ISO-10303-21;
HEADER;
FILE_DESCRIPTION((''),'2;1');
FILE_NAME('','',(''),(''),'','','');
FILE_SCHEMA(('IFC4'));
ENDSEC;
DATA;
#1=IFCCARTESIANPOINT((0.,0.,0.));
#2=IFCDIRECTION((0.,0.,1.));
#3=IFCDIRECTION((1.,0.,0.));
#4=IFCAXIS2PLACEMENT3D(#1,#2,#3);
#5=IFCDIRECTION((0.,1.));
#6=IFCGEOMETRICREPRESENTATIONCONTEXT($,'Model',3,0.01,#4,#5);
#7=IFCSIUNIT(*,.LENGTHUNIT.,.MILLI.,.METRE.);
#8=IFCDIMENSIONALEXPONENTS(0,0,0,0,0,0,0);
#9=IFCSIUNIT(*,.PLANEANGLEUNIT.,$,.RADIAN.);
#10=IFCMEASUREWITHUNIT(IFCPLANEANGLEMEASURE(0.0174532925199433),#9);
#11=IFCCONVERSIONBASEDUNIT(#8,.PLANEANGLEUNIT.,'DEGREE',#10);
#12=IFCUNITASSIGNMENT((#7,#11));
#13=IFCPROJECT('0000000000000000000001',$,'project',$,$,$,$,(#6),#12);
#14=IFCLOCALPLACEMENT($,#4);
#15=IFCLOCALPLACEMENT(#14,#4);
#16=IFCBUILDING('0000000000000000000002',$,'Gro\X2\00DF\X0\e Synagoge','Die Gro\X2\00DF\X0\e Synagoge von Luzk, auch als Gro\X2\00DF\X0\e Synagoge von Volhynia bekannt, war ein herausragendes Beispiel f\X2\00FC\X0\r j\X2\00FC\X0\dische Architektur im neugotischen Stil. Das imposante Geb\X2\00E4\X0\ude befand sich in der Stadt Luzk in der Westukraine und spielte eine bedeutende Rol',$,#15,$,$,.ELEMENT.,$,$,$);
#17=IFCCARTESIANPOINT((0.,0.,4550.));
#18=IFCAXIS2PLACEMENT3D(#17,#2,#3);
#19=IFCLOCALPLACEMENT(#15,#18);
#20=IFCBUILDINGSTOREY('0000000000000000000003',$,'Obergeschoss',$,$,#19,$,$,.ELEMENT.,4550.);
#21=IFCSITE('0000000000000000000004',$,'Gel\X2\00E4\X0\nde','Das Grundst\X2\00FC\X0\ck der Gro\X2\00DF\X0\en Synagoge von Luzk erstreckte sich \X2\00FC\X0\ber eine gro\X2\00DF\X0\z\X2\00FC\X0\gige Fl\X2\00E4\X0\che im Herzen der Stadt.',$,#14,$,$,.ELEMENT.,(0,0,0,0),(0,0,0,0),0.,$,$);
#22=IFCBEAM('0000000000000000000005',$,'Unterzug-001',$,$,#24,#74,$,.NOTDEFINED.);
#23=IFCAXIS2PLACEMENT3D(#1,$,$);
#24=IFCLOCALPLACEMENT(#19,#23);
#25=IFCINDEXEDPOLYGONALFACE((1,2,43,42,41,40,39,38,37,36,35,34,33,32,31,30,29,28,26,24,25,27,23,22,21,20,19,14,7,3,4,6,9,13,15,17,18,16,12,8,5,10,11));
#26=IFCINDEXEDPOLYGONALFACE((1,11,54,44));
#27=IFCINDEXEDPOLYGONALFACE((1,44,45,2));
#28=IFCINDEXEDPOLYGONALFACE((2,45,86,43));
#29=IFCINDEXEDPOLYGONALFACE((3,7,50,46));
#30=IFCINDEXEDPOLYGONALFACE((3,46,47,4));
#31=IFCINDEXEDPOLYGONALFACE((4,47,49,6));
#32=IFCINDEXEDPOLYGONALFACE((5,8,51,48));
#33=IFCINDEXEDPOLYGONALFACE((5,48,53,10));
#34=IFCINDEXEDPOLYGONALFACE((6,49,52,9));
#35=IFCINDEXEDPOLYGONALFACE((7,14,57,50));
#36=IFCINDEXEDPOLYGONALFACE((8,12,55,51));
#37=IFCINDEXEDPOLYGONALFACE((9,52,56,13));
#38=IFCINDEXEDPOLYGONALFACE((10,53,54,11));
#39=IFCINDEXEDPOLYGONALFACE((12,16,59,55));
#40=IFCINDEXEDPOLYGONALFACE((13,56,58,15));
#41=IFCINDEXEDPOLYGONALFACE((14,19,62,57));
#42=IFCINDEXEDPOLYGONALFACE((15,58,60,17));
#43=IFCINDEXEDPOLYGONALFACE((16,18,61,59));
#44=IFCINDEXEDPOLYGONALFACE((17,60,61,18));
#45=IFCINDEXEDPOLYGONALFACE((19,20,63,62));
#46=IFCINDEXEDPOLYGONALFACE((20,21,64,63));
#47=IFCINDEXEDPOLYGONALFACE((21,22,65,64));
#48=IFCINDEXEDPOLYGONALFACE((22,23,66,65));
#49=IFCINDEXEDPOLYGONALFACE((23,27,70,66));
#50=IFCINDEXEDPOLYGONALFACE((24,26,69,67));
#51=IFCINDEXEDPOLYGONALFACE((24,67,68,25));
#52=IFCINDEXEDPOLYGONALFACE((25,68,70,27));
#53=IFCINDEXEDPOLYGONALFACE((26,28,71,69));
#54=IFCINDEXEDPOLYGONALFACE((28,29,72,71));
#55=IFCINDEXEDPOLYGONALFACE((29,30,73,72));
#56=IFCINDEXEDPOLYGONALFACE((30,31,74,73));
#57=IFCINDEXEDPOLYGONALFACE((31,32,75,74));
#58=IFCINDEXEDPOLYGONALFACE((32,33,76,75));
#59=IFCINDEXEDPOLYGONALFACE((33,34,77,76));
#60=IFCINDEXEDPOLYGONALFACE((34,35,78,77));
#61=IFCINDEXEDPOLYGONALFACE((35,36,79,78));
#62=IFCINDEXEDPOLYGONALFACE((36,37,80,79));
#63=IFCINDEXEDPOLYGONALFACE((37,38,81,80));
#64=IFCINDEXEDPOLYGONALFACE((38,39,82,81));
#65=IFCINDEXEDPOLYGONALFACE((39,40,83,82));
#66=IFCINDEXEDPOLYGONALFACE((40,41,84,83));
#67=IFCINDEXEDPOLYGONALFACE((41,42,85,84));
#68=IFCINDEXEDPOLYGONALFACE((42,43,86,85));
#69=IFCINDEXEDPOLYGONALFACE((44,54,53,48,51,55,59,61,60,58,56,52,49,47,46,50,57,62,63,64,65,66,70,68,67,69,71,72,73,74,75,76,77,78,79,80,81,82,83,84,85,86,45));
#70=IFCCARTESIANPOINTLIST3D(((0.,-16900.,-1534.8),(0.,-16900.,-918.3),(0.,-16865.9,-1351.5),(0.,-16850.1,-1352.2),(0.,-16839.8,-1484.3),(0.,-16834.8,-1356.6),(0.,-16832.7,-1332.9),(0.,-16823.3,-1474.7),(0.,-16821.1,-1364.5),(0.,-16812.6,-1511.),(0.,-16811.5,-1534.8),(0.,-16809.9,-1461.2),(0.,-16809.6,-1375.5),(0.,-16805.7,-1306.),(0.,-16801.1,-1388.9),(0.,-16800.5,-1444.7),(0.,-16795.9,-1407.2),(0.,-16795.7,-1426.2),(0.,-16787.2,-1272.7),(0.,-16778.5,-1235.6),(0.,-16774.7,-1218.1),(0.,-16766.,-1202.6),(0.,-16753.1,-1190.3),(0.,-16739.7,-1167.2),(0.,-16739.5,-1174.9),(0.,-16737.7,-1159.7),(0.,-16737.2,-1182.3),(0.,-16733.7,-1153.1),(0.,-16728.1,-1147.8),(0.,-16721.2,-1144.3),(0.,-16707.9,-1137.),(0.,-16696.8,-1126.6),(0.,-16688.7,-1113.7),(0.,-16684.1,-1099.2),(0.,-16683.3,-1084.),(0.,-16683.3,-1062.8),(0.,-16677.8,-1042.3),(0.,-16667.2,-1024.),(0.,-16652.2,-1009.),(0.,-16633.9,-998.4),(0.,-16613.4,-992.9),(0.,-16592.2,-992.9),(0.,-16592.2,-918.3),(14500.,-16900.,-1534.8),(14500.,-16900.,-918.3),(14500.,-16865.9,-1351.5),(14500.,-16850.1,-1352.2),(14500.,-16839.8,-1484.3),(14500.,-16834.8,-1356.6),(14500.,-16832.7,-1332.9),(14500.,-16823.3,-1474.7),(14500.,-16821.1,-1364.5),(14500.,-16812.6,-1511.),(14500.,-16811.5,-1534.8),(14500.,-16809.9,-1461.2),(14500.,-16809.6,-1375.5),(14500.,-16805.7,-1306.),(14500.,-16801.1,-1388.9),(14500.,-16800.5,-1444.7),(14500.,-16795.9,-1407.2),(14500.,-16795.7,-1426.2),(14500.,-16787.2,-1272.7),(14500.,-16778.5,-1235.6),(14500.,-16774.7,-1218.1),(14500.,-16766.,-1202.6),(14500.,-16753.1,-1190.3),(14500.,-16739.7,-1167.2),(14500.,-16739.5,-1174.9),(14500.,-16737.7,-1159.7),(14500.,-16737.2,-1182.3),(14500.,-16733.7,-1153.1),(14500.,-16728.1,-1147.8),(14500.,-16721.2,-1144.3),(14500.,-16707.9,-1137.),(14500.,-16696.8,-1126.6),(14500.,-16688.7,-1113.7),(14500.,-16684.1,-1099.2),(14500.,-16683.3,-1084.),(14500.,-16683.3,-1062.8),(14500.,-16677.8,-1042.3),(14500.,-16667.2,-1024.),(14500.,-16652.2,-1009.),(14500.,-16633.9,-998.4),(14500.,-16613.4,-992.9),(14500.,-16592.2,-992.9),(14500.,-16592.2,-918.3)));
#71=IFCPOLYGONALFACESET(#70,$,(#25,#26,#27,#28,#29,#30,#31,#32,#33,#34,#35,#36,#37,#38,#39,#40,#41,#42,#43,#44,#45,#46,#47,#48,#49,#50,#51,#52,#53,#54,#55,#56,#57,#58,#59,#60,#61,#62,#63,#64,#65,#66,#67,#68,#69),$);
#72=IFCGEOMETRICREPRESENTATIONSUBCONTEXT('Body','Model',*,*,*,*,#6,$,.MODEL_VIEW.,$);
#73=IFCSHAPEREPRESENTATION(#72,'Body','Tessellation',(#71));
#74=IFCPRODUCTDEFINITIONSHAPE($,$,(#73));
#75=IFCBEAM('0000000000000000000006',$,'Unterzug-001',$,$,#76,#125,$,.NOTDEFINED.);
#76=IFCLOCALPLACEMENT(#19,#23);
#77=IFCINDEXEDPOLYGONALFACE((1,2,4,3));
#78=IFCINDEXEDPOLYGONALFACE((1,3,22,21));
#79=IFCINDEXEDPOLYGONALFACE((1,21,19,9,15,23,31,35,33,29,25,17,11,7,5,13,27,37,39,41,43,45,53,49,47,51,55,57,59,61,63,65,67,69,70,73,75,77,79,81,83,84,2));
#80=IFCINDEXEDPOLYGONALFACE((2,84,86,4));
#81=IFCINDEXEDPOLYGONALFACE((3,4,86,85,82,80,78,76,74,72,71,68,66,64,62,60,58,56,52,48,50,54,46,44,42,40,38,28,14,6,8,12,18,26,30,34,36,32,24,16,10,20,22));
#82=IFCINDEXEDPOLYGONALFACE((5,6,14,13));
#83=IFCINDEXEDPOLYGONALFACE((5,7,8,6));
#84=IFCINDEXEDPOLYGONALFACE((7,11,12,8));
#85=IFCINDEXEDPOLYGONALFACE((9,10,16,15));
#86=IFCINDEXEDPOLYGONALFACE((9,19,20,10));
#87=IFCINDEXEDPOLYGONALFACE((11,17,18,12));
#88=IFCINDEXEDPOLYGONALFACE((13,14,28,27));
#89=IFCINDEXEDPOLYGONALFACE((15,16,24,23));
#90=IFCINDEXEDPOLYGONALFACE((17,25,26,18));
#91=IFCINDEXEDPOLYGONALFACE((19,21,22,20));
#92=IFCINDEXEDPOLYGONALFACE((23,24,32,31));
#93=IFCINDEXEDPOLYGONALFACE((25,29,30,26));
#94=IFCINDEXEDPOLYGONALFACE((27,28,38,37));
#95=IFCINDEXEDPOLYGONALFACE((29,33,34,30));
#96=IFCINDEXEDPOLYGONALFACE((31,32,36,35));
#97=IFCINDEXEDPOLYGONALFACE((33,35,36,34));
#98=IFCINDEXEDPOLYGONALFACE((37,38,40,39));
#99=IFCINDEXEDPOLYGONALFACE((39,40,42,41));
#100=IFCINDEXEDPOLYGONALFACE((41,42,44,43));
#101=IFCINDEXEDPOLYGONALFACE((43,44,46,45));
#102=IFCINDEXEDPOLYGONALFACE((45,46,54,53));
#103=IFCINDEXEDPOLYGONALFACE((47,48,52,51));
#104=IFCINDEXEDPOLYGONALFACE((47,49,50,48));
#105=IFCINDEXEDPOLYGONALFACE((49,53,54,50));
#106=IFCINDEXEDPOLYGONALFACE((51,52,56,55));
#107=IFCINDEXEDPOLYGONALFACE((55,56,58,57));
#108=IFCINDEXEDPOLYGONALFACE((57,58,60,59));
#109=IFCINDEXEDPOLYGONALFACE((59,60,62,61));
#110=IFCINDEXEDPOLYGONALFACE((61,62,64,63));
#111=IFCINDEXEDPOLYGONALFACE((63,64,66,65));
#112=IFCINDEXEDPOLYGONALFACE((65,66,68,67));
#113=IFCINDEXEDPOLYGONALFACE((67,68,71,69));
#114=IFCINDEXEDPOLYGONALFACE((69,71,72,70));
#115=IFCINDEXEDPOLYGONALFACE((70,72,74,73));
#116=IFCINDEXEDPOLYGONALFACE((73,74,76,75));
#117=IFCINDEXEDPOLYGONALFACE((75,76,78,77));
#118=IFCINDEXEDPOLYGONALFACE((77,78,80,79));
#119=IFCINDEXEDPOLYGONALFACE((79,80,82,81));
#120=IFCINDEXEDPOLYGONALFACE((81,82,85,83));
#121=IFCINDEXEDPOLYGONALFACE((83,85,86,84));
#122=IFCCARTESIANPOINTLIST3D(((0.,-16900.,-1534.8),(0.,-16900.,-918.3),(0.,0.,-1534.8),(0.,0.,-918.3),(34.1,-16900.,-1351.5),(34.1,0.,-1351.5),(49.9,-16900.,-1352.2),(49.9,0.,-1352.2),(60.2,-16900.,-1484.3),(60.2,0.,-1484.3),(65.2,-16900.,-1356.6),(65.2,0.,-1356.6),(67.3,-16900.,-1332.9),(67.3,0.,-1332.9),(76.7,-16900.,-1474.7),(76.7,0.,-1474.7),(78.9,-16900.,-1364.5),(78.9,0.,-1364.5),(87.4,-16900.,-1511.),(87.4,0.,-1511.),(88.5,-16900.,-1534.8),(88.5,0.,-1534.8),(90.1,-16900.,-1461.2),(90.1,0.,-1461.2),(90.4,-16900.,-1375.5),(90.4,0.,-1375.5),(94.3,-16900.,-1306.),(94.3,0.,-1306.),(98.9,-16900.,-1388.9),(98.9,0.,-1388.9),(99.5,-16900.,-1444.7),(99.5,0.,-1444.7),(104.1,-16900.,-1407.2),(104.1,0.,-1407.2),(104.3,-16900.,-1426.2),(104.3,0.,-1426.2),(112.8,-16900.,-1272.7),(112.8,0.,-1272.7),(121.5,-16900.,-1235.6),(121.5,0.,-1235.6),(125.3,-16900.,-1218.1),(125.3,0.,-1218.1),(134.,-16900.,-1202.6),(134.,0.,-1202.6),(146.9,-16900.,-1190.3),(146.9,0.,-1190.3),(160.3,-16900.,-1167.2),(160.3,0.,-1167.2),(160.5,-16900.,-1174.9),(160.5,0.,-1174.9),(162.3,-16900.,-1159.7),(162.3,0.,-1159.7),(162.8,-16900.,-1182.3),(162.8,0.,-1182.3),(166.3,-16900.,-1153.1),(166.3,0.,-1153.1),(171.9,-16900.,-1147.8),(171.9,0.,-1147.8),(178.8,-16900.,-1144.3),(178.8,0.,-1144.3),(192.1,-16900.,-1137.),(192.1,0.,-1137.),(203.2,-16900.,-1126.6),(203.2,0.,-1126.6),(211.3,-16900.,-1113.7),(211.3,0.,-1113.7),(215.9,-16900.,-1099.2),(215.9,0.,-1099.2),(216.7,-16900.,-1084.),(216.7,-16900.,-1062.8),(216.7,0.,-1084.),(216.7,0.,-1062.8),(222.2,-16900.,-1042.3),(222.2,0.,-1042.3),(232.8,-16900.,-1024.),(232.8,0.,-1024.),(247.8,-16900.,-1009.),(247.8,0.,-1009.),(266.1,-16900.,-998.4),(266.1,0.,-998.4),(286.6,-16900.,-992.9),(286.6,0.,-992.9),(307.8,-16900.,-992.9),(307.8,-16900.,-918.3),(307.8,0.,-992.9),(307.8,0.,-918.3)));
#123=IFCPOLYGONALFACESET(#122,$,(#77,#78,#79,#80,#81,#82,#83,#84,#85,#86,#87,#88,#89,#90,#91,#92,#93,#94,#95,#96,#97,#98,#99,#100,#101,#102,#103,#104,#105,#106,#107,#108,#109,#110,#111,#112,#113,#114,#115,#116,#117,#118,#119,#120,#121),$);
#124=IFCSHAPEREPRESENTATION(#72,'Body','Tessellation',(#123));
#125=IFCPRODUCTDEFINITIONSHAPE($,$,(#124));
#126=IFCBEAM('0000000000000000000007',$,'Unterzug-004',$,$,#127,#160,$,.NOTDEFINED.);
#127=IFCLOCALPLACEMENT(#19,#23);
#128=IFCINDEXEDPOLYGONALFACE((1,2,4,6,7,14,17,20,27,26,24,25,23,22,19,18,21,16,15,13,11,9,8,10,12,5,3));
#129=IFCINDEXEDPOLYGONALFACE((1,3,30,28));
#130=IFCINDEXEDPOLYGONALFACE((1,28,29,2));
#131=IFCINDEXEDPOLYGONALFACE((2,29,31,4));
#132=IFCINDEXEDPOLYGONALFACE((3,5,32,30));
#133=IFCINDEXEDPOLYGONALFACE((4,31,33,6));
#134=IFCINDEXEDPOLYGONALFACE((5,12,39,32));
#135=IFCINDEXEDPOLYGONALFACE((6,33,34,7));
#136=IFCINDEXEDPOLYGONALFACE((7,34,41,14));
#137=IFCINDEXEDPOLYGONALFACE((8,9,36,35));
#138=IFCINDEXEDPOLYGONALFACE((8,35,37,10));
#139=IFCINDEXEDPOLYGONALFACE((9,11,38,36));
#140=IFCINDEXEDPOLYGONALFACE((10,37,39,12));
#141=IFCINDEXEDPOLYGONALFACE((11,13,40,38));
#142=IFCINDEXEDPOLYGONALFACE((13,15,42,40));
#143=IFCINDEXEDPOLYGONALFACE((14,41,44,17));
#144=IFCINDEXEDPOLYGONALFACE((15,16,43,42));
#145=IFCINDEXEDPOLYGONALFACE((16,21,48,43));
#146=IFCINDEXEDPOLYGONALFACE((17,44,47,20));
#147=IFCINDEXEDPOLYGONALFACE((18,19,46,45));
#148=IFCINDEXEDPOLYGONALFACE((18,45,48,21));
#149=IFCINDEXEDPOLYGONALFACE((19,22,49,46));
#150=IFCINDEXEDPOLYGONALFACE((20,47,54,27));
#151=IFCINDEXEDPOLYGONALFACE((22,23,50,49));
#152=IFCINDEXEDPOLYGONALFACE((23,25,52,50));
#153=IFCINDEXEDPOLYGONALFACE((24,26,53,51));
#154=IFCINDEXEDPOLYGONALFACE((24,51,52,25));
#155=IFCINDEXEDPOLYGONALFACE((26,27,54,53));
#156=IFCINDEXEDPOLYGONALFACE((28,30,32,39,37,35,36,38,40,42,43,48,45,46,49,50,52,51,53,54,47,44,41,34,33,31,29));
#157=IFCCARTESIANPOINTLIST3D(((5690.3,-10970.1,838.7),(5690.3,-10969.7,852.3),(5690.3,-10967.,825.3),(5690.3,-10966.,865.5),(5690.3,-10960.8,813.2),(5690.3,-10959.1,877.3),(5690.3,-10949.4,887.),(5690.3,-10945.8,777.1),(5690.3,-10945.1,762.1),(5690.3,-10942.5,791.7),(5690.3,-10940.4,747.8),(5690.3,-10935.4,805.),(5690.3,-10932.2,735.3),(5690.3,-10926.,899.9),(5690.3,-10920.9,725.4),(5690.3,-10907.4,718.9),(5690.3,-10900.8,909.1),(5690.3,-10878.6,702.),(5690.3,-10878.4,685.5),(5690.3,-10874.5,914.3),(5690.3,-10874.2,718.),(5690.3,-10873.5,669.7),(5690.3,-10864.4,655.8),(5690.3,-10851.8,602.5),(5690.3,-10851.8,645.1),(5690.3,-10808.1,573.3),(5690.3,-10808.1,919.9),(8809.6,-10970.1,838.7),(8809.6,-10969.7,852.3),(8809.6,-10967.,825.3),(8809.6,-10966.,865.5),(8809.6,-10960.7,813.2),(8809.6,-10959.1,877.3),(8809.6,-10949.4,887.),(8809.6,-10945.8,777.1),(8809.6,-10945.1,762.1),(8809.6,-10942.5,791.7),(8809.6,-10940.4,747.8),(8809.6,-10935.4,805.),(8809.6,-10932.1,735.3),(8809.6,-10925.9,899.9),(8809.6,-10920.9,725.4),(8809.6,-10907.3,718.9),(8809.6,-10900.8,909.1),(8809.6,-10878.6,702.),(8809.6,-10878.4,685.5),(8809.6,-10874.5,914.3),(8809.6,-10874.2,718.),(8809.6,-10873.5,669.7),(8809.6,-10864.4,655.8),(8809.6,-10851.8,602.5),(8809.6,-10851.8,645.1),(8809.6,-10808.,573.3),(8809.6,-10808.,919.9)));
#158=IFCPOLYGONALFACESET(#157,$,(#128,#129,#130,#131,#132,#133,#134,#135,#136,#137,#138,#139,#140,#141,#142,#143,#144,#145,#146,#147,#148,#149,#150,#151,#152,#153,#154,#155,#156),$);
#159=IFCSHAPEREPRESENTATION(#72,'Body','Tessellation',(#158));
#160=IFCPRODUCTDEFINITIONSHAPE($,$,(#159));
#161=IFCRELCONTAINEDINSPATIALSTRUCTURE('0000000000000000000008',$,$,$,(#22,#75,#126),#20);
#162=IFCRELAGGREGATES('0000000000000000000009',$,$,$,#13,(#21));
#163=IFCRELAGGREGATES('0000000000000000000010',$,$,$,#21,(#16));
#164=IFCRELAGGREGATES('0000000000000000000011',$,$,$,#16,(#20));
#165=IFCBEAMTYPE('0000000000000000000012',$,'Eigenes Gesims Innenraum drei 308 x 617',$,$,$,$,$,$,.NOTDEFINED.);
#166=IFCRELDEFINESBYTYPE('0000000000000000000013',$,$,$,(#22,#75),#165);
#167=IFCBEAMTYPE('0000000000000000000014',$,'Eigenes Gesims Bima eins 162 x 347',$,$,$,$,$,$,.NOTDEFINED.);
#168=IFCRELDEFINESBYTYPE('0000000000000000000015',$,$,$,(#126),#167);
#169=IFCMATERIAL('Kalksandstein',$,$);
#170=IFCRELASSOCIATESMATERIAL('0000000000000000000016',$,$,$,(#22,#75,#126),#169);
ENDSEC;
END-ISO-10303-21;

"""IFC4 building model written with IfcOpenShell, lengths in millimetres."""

from ifc_helpers import new_model, entity, si_unit, converted_unit, direction, frame, origin_with_axes, place, context, subcontext, project, spatial, line, arc, indexed_curve, outline, extrude, material, material_profile, profile_set, type_object, element, save


model = new_model("IFC4")

# Units and contexts
model_context = context("Model", 3, precision=0.01, world=origin_with_axes(), true_north=direction((0.0, 1.0)))
body_context = subcontext(model_context, "Body", "Model", "MODEL_VIEW")
ifc_project = project(units=[si_unit("LENGTHUNIT", "METRE", prefix="MILLI"), converted_unit("PLANEANGLEUNIT", "DEGREE", entity("IfcPlaneAngleMeasure", 0.0174532925199433), si_unit("PLANEANGLEUNIT", "RADIAN"), dimensions=[0, 0, 0, 0, 0, 0, 0])], contexts=[model_context])

# Site, building, storey
site_placement = place(None, origin_with_axes())
site = spatial("IfcSite", under=ifc_project, at=site_placement, Name="Gelände", Description="Das Grundstück der Großen Synagoge von Luzk erstreckte sich über eine großzügige Fläche im Herzen der Stadt.", CompositionType="ELEMENT", RefLatitude=(0, 0, 0, 0), RefLongitude=(0, 0, 0, 0), RefElevation=0.0)
building_placement = place(site_placement, origin_with_axes())
building = spatial("IfcBuilding", under=site, at=building_placement, Name="Große Synagoge", Description="Die Große Synagoge von Luzk, auch als Große Synagoge von Volhynia bekannt, war ein herausragendes Beispiel für jüdische Architektur im neugotischen Stil. Das imposante Gebäude befand sich in der Stadt Luzk in der Westukraine und spielte eine bedeutende Rol", CompositionType="ELEMENT")
storey_placement = place(building_placement, frame((0.0, 0.0, 4550.0), z_axis=(0.0, 0.0, 1.0), x_axis=(1.0, 0.0, 0.0)))
storey = spatial("IfcBuildingStorey", under=building, at=storey_placement, Name="Obergeschoss", CompositionType="ELEMENT", Elevation=4550.0)

# Beams
ifc_material_1 = material(Name="Kalksandstein")
ifc_material_profile_1 = material_profile(ifc_material_1, outline(indexed_curve([(121.5, -317.3), (134.0, -284.3), (162.8, -264.0), (162.3, -241.4), (178.8, -226.0), (207.7, -202.1), (216.7, -165.7), (239.8, -97.7), (307.8, -74.6), (307.8, 0.0), (0.0, 0.0), (0.0, -616.6), (88.5, -616.6), (87.4, -592.7), (60.2, -566.0), (99.5, -526.4), (98.9, -470.6), (72.3, -441.9), (34.1, -433.2), (94.3, -387.7)], segments=[arc(1, 2, 3), arc(3, 4, 5), arc(5, 6, 7), arc(7, 8, 9), line(9, 10, 11, 12, 13, 14, 15), arc(15, 16, 17), arc(17, 18, 19), arc(19, 20, 1)])), Name="Kalksandstein")
ifc_profile_set_1 = profile_set([ifc_material_profile_1], Name="Eigenes Gesims Innenraum drei")
beam_type_1 = type_object("IfcBeamType", Name="Eigenes Gesims Innenraum drei 308 x 617", PredefinedType="NOTDEFINED")
beam_1_placement = place(storey_placement, frame((0.0, -16900.0, -918.3), z_axis=(0.0, 0.0, 1.0), x_axis=(0.0, -1.0, 0.0)))
element("IfcBeam", 1, at=beam_1_placement, inside=storey, type_object=beam_type_1, material=ifc_profile_set_1, Name="Unterzug-001", PredefinedType="NOTDEFINED", context=body_context, shape_type="SweptSolid", body=[
    extrude(outline(indexed_curve([(121.5, -317.3), (134.0, -284.3), (162.8, -264.0), (162.3, -241.4), (178.8, -226.0), (207.7, -202.1), (216.7, -165.7), (239.8, -97.7), (307.8, -74.6), (307.8, 0.0), (0.0, 0.0), (0.0, -616.6), (88.5, -616.6), (87.4, -592.7), (60.2, -566.0), (99.5, -526.4), (98.9, -470.6), (72.3, -441.9), (34.1, -433.2), (94.3, -387.7)], segments=[arc(1, 2, 3), arc(3, 4, 5), arc(5, 6, 7), arc(7, 8, 9), line(9, 10, 11, 12, 13, 14, 15), arc(15, 16, 17), arc(17, 18, 19), arc(19, 20, 1)])), frame((0.0, 14500.0, 0.0), z_axis=(0.0, 1.0, 0.0), x_axis=(-1.0, 0.0, 0.0)), (0.0, 0.0, -1.0), 14500.0),
])
beam_2_placement = place(storey_placement, frame((0.0, -16900.0, -918.3), z_axis=(0.0, 0.0, 1.0), x_axis=(1.0, 0.0, 0.0)))
element("IfcBeam", 2, at=beam_2_placement, inside=storey, type_object=beam_type_1, material=ifc_profile_set_1, Name="Unterzug-001", PredefinedType="NOTDEFINED", context=body_context, shape_type="SweptSolid", body=[
    extrude(outline(indexed_curve([(121.5, -317.3), (134.0, -284.3), (162.8, -264.0), (162.3, -241.4), (178.8, -226.0), (207.7, -202.1), (216.7, -165.7), (239.8, -97.7), (307.8, -74.6), (307.8, 0.0), (0.0, 0.0), (0.0, -616.6), (88.5, -616.6), (87.4, -592.7), (60.2, -566.0), (99.5, -526.4), (98.9, -470.6), (72.3, -441.9), (34.1, -433.2), (94.3, -387.7)], segments=[arc(1, 2, 3), arc(3, 4, 5), arc(5, 6, 7), arc(7, 8, 9), line(9, 10, 11, 12, 13, 14, 15), arc(15, 16, 17), arc(17, 18, 19), arc(19, 20, 1)])), frame((0.0, 16900.0, 0.0), z_axis=(0.0, -1.0, 0.0), x_axis=(1.0, 0.0, 0.0)), (0.0, 0.0, 1.0), 16900.0),
])
ifc_material_profile_2 = material_profile(ifc_material_1, outline(indexed_curve([(127.4, -114.9), (152.7, -106.7), (161.7, -67.6), (141.4, -32.9), (105.5, -14.9), (66.5, -5.6), (0.0, 0.0), (0.0, -346.6), (43.7, -317.4), (43.7, -274.8), (68.5, -242.5), (66.2, -201.9), (99.3, -201.0), (135.2, -165.1)], segments=[line(1, 2), arc(2, 3, 4), arc(4, 5, 6), line(6, 7, 8, 9, 10), arc(10, 11, 12), line(12, 13), arc(13, 14, 1)])), Name="Kalksandstein")
ifc_profile_set_2 = profile_set([ifc_material_profile_2], Name="Eigenes Gesims Bima eins")
beam_type_2 = type_object("IfcBeamType", Name="Eigenes Gesims Bima eins 162 x 347", PredefinedType="NOTDEFINED")
beam_3_placement = place(storey_placement, frame((5690.3, -10808.1, 919.9), z_axis=(0.0, 0.0, 1.0), x_axis=(0.000006, -1.0, 0.0)))
element("IfcBeam", 3, at=beam_3_placement, inside=storey, type_object=beam_type_2, material=ifc_profile_set_2, Name="Unterzug-004", PredefinedType="NOTDEFINED", context=body_context, shape_type="SweptSolid", body=[
    extrude(outline(indexed_curve([(127.4, -114.9), (152.7, -106.7), (161.7, -67.6), (141.4, -32.9), (105.5, -14.9), (66.5, -5.6), (0.0, 0.0), (0.0, -346.6), (43.7, -317.4), (43.7, -274.8), (68.5, -242.5), (66.2, -201.9), (99.3, -201.0), (135.2, -165.1)], segments=[line(1, 2), arc(2, 3, 4), arc(4, 5, 6), line(6, 7, 8, 9, 10), arc(10, 11, 12), line(12, 13), arc(13, 14, 1)])), frame((0.0, 3119.3, 0.0), z_axis=(0.0, -1.0, 0.0), x_axis=(1.0, 0.0, 0.0)), (0.0, 0.0, 1.0), 3119.3),
])

save(model, "model.ifc")
